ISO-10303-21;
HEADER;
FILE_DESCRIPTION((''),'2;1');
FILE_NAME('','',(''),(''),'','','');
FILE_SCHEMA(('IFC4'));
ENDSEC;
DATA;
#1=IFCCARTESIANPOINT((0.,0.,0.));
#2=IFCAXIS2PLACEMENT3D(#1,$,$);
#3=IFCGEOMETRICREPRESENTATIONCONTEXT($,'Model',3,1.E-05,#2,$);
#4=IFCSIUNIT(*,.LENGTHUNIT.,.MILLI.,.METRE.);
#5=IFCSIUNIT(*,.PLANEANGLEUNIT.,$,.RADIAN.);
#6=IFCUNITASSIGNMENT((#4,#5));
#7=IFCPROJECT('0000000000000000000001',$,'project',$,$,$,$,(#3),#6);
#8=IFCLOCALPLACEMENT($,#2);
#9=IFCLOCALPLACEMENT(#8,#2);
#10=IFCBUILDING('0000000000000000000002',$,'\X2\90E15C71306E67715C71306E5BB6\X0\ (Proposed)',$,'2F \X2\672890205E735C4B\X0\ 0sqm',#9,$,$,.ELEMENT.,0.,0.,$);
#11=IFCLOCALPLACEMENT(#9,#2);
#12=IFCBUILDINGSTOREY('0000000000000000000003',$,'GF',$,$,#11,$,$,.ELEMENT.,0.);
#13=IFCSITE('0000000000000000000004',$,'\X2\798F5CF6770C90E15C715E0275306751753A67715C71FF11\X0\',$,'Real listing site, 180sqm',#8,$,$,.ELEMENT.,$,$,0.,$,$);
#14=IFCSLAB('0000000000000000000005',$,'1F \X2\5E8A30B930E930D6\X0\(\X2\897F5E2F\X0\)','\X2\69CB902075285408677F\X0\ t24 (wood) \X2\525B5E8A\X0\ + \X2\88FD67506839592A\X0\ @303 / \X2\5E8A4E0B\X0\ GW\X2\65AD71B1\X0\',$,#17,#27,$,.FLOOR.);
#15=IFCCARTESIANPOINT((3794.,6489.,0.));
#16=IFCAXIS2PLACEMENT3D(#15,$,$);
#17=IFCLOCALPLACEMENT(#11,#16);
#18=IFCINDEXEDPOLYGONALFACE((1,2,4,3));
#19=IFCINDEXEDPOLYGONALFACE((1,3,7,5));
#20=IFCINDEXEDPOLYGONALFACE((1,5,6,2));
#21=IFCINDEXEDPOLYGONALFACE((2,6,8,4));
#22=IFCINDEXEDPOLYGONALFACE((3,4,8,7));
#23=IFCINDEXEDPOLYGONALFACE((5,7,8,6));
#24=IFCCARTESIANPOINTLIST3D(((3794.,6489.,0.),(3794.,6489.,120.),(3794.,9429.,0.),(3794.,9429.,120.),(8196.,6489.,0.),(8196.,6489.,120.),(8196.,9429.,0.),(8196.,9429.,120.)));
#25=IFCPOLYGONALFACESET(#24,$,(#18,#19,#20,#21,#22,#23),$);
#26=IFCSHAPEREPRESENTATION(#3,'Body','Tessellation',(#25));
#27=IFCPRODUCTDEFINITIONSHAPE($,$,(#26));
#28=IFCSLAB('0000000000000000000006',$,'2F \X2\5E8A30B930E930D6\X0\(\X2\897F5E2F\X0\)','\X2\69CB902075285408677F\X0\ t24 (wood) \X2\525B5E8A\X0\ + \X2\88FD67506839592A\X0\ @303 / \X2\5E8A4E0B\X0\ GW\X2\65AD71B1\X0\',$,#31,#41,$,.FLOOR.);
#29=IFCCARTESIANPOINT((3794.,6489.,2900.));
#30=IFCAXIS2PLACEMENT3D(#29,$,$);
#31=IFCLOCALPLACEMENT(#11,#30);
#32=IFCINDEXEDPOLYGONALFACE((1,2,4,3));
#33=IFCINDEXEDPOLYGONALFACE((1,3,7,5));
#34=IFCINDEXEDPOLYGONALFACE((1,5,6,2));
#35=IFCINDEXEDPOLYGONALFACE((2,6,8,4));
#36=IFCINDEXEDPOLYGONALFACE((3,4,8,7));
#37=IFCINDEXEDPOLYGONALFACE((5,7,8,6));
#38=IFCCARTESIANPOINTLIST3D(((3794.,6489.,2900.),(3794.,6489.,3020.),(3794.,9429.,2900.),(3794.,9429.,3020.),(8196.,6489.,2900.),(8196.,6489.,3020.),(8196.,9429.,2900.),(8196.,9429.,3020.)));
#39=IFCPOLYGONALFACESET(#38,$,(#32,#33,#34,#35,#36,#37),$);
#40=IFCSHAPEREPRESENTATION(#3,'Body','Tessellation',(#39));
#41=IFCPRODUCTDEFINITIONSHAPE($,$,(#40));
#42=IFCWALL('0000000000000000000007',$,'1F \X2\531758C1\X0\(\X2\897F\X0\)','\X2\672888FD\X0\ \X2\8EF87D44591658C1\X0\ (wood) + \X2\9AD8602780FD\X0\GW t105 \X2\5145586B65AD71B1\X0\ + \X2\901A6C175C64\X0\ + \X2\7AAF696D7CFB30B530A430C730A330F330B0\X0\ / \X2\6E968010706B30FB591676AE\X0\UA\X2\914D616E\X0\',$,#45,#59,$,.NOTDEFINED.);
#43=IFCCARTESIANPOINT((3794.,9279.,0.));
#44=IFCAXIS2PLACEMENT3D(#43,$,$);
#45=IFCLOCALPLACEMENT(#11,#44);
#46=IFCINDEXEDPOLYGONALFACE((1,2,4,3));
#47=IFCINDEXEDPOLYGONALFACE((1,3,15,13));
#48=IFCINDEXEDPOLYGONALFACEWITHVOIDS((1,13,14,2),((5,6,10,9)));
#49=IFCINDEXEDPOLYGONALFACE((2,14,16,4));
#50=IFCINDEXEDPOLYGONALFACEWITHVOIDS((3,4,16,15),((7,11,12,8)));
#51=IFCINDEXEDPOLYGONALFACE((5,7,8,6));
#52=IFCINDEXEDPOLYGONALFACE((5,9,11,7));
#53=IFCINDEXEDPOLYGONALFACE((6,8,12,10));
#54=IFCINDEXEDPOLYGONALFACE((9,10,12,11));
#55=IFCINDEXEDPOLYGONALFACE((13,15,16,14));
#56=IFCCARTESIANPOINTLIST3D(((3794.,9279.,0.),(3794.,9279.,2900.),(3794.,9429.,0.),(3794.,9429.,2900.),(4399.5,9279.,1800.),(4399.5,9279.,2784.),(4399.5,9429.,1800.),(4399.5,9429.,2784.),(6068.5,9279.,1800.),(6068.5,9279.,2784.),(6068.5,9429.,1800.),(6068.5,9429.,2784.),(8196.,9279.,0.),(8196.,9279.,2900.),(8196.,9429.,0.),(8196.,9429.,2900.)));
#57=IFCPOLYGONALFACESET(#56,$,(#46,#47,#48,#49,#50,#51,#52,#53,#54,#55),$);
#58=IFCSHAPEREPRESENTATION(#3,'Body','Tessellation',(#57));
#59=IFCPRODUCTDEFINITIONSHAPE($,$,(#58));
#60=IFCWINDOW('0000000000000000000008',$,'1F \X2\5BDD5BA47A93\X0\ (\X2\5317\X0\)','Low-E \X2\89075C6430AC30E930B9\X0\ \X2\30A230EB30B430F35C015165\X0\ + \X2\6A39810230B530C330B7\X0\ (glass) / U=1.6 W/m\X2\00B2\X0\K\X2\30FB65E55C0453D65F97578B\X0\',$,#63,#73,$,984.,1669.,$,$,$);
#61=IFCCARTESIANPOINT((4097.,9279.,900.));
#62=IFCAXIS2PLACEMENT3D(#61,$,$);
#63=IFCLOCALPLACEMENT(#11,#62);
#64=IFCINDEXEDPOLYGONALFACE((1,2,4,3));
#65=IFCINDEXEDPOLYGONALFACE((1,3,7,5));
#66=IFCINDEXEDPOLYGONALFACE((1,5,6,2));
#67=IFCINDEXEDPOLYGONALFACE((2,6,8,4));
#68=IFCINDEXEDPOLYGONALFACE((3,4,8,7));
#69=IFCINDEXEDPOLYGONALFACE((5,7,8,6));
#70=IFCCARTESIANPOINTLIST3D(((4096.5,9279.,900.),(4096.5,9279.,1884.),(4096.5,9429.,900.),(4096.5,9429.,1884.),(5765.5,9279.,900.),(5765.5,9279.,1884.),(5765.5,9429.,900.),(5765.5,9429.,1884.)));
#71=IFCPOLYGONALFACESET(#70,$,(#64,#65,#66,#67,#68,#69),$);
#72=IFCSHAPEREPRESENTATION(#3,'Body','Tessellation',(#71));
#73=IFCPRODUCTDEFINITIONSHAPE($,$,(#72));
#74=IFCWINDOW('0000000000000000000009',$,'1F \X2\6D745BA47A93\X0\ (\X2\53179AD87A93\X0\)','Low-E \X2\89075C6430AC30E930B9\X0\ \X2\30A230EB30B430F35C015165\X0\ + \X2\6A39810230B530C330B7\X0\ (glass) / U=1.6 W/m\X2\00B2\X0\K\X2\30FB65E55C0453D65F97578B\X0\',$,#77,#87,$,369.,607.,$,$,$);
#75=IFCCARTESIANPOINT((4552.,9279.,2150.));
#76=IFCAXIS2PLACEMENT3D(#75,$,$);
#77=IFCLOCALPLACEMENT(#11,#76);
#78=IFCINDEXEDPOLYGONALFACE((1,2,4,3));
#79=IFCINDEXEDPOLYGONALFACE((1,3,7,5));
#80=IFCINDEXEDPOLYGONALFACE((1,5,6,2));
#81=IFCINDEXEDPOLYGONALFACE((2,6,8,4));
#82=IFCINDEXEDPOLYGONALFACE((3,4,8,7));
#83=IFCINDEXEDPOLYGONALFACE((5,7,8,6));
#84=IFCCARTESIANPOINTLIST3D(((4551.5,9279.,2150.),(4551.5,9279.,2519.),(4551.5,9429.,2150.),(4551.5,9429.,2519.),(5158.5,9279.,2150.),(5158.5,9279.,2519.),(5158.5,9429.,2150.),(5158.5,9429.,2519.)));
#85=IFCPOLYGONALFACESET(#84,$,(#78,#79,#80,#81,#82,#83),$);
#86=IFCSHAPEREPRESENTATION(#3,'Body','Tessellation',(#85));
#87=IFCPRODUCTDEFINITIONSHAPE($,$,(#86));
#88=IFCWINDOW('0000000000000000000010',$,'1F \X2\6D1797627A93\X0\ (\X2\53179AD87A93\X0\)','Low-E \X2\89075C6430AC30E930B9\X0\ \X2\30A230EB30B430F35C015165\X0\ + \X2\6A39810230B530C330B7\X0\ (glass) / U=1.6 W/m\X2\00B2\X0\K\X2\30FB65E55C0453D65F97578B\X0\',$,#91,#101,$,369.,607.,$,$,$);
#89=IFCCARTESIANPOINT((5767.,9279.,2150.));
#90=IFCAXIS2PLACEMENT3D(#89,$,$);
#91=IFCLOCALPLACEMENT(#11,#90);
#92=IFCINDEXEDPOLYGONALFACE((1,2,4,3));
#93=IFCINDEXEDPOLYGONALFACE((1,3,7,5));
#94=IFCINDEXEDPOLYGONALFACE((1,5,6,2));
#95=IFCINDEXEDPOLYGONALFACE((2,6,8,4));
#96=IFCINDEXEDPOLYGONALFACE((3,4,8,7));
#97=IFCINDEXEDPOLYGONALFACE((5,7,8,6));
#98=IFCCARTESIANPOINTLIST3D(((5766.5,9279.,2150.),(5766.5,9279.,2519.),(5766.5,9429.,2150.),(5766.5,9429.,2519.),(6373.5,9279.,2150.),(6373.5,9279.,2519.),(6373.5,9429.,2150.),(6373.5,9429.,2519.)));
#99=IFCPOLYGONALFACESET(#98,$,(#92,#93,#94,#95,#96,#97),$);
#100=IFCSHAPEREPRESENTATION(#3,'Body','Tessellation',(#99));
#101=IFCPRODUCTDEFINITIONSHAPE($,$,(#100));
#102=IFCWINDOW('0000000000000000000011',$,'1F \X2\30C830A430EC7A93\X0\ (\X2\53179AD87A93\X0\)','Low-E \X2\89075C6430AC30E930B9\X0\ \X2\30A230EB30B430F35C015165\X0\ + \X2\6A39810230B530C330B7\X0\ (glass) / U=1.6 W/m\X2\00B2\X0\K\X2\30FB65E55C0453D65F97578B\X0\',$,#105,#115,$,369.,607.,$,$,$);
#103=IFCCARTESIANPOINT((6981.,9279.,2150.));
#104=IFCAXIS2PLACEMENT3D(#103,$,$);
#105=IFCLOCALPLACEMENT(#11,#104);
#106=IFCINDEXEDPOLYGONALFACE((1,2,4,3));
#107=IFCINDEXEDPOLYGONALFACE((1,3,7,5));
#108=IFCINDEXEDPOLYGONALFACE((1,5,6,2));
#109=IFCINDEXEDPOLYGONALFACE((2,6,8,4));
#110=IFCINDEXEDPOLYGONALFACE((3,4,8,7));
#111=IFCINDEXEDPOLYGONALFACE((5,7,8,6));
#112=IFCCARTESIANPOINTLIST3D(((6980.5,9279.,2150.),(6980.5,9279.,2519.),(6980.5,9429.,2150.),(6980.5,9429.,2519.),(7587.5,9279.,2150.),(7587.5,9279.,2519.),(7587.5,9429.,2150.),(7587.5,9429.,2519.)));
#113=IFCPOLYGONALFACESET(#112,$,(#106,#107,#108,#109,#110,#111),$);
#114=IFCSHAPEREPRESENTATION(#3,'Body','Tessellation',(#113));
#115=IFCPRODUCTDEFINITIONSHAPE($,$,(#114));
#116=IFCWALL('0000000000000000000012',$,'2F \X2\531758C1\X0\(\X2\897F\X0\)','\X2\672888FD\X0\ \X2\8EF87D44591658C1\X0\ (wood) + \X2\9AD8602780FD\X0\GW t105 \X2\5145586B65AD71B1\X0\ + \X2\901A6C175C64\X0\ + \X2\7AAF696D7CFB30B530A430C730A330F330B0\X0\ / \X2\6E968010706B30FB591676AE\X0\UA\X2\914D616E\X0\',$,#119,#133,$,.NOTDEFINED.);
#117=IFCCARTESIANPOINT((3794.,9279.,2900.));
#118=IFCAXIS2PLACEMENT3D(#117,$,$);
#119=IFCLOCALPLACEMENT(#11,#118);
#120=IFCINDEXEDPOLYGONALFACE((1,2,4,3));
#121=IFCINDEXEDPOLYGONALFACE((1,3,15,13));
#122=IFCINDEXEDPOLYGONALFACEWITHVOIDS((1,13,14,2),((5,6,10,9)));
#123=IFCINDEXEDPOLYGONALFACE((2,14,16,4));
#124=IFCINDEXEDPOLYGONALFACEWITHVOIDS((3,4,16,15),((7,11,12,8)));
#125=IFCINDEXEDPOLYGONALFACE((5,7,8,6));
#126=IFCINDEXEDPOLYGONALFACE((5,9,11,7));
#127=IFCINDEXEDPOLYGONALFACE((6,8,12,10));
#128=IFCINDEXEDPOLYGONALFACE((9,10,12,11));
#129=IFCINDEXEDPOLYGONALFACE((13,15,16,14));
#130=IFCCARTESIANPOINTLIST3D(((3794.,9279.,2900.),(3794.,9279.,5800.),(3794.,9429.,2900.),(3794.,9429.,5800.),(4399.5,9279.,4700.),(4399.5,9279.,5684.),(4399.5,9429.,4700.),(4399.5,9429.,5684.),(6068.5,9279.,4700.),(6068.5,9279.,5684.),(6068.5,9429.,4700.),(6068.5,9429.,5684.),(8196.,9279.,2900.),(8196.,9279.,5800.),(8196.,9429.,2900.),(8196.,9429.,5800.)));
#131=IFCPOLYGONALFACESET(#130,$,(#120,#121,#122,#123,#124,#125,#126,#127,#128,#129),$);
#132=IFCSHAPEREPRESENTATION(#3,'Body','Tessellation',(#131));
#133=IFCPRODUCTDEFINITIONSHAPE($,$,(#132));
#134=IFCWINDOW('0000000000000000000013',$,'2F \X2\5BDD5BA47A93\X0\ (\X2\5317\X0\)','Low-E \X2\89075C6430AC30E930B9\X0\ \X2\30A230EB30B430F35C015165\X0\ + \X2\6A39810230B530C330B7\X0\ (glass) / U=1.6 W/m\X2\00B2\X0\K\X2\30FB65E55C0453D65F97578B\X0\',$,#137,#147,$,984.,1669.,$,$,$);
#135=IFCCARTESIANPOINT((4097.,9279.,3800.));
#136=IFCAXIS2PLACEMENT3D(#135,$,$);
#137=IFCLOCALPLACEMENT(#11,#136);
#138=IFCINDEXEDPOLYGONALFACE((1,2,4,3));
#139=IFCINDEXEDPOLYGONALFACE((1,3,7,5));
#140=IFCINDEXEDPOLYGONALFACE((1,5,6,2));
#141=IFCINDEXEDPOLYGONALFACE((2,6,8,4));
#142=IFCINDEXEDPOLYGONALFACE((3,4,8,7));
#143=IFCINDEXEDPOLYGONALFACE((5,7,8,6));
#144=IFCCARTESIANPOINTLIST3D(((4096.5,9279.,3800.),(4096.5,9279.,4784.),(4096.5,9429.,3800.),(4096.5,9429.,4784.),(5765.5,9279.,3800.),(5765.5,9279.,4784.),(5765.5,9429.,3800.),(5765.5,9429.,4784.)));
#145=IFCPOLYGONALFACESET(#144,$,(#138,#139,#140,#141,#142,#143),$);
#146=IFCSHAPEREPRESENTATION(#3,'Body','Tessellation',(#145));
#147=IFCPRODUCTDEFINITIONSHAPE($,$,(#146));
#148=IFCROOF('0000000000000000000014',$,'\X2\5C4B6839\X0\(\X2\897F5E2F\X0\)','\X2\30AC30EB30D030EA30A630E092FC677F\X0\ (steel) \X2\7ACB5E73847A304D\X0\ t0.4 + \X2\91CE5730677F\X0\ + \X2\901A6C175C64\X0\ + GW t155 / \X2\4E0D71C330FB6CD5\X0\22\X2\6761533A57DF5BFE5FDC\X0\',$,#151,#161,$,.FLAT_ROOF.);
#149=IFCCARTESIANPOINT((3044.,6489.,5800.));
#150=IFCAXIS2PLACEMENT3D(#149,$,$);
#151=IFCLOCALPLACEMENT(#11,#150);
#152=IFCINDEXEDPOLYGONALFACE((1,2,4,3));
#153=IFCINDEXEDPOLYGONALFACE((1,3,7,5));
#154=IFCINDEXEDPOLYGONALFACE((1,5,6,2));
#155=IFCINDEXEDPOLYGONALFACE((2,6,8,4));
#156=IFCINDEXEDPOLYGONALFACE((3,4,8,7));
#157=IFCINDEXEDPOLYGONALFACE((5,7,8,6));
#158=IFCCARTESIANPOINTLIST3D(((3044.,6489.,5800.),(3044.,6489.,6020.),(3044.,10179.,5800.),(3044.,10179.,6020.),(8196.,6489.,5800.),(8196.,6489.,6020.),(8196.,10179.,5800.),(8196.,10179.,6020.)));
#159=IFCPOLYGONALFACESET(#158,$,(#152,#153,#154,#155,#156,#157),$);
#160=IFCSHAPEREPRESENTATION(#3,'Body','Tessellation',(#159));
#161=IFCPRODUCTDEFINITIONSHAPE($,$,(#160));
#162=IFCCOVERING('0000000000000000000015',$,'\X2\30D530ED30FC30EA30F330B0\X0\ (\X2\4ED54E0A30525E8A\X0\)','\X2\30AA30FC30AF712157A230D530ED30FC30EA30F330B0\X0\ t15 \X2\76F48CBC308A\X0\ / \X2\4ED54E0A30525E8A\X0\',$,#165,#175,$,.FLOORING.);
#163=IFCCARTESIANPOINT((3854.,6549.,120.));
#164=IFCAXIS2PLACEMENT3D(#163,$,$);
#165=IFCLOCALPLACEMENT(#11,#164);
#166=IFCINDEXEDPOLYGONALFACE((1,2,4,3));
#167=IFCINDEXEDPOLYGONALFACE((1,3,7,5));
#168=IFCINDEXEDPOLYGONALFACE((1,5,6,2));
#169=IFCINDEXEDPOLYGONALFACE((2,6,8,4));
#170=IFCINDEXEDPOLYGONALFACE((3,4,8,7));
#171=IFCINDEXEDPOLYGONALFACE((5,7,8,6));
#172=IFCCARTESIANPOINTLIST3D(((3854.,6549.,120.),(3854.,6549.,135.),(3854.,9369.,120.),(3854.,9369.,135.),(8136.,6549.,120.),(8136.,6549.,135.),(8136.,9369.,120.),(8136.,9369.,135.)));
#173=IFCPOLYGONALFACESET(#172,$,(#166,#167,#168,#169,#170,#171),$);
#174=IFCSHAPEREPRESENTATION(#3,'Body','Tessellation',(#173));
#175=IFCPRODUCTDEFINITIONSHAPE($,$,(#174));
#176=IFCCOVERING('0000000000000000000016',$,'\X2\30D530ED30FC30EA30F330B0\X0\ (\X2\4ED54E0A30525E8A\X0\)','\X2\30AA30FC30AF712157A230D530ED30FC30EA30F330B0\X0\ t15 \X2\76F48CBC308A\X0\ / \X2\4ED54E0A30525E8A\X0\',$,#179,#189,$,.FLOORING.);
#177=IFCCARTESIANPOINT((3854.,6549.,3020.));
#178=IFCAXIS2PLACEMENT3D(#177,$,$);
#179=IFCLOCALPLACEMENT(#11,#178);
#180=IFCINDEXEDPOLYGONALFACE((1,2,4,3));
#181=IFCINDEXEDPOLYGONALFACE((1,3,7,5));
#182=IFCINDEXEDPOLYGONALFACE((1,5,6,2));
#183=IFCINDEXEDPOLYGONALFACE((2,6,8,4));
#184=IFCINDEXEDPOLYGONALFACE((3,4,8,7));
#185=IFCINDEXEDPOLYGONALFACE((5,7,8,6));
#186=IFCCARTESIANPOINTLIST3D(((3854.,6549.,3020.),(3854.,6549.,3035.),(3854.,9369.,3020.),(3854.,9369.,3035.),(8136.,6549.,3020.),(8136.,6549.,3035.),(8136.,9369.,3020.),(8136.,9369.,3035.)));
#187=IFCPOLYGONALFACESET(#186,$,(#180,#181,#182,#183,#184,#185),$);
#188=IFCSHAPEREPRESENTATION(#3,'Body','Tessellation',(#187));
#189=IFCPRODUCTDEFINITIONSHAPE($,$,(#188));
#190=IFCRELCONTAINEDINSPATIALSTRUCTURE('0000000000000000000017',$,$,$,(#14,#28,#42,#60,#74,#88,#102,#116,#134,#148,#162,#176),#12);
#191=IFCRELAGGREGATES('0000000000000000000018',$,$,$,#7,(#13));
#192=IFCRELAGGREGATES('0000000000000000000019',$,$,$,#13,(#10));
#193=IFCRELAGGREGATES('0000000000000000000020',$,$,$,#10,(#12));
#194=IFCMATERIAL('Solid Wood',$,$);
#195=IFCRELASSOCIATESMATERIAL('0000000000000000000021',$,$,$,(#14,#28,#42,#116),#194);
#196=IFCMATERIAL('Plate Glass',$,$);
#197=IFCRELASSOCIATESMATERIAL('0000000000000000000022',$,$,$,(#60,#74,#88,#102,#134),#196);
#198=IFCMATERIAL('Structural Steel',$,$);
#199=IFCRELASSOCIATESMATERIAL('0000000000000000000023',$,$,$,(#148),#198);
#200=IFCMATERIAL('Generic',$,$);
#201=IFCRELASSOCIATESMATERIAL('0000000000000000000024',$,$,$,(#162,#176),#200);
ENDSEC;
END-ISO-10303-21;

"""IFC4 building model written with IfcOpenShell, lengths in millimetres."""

from ifc_helpers import new_model, si_unit, frame, frame_2d, origin, place, context, project, spatial, rectangle, extrude, material, element, fill, save


model = new_model("IFC4")

# Units and contexts
model_context = context("Model", 3, precision=1e-05, world=origin())
ifc_project = project(units=[si_unit("LENGTHUNIT", "METRE", prefix="MILLI"), si_unit("PLANEANGLEUNIT", "RADIAN")], contexts=[model_context])

# Site, building, storey
site_placement = place(None, origin())
site = spatial("IfcSite", under=ifc_project, at=site_placement, Name="福島県郡山市田村町東山１", ObjectType="Real listing site, 180sqm", CompositionType="ELEMENT", RefElevation=0.0)
building_placement = place(site_placement, origin())
building = spatial("IfcBuilding", under=site, at=building_placement, Name="郡山の東山の家 (Proposed)", ObjectType="2F 木造平屋 0sqm", CompositionType="ELEMENT", ElevationOfRefHeight=0.0, ElevationOfTerrain=0.0)
storey_placement = place(building_placement, origin())
storey = spatial("IfcBuildingStorey", under=building, at=storey_placement, Name="GF", CompositionType="ELEMENT", Elevation=0.0)

# Slabs
ifc_material_1 = material(Name="Solid Wood")
slab_1_placement = place(storey_placement, frame((3794.0, 6489.0, 0.0)))
element("IfcSlab", 1, at=slab_1_placement, inside=storey, material=ifc_material_1, Name="1F 床スラブ(西帯)", Description="構造用合板 t24 (wood) 剛床 + 製材根太 @303 / 床下 GW断熱", PredefinedType="FLOOR", context=model_context, shape_type="SweptSolid", body=[
    extrude(rectangle(XDim=4402.0, YDim=2940.0, at=frame_2d((2201.0, 1470.0))), frame((3794.0, 6489.0, 0.0)), (0.0, 0.0, 1.0), 120.0),
])
slab_2_placement = place(storey_placement, frame((3794.0, 6489.0, 2900.0)))
element("IfcSlab", 2, at=slab_2_placement, inside=storey, material=ifc_material_1, Name="2F 床スラブ(西帯)", Description="構造用合板 t24 (wood) 剛床 + 製材根太 @303 / 床下 GW断熱", PredefinedType="FLOOR", context=model_context, shape_type="SweptSolid", body=[
    extrude(rectangle(XDim=4402.0, YDim=2940.0, at=frame_2d((2201.0, 1470.0))), frame((3794.0, 6489.0, 2900.0)), (0.0, 0.0, 1.0), 120.0),
])

# Wall, openings, windows
wall_1_placement = place(storey_placement, frame((3794.0, 9279.0, 0.0)))
wall_1 = element("IfcWall", 3, at=wall_1_placement, inside=storey, material=ifc_material_1, Name="1F 北壁(西)", Description="木製 軸組外壁 (wood) + 高性能GW t105 充填断熱 + 通気層 + 窯業系サイディング / 準耐火・外皮UA配慮", PredefinedType="NOTDEFINED", context=model_context, shape_type="SweptSolid", body=[
    extrude(rectangle(XDim=4402.0, YDim=150.0, at=frame_2d((2201.0, 75.0))), frame((3794.0, 9279.0, 0.0)), (0.0, 0.0, 1.0), 2900.0),
])
opening_1_placement = place(storey_placement, frame((4097.0, 9279.0, 900.0)))
opening_1 = element("IfcOpeningElement", 4, at=opening_1_placement, cuts=wall_1, PredefinedType="NOTDEFINED", context=model_context, shape_type="SweptSolid", body=[
    extrude(rectangle(XDim=1669.0, YDim=150.0, at=frame_2d((834.0, 75.0))), frame((4097.0, 9279.0, 900.0)), (0.0, 0.0, 1.0), 984.0),
])
opening_2_placement = place(storey_placement, frame((4552.0, 9279.0, 2150.0)))
opening_2 = element("IfcOpeningElement", 5, at=opening_2_placement, cuts=wall_1, PredefinedType="NOTDEFINED", context=model_context, shape_type="SweptSolid", body=[
    extrude(rectangle(XDim=607.0, YDim=150.0, at=frame_2d((303.0, 75.0))), frame((4552.0, 9279.0, 2150.0)), (0.0, 0.0, 1.0), 369.0),
])
opening_3_placement = place(storey_placement, frame((5767.0, 9279.0, 2150.0)))
opening_3 = element("IfcOpeningElement", 6, at=opening_3_placement, cuts=wall_1, PredefinedType="NOTDEFINED", context=model_context, shape_type="SweptSolid", body=[
    extrude(rectangle(XDim=607.0, YDim=150.0, at=frame_2d((303.0, 75.0))), frame((5767.0, 9279.0, 2150.0)), (0.0, 0.0, 1.0), 369.0),
])
opening_4_placement = place(storey_placement, frame((6981.0, 9279.0, 2150.0)))
opening_4 = element("IfcOpeningElement", 7, at=opening_4_placement, cuts=wall_1, PredefinedType="NOTDEFINED", context=model_context, shape_type="SweptSolid", body=[
    extrude(rectangle(XDim=607.0, YDim=150.0, at=frame_2d((303.0, 75.0))), frame((6981.0, 9279.0, 2150.0)), (0.0, 0.0, 1.0), 369.0),
])
ifc_material_2 = material(Name="Plate Glass")
window_1_placement = place(storey_placement, frame((4097.0, 9279.0, 900.0)))
window_1 = element("IfcWindow", 8, at=window_1_placement, inside=storey, material=ifc_material_2, Name="1F 寝室窓 (北)", Description="Low-E 複層ガラス アルゴン封入 + 樹脂サッシ (glass) / U=1.6 W/m²K・日射取得型", OverallHeight=984.0, OverallWidth=1669.0, context=model_context, shape_type="SweptSolid", body=[
    extrude(rectangle(XDim=1669.0, YDim=150.0, at=frame_2d((834.0, 75.0))), frame((4097.0, 9279.0, 900.0)), (0.0, 0.0, 1.0), 984.0),
])
fill(opening_1, window_1)
window_2_placement = place(storey_placement, frame((4552.0, 9279.0, 2150.0)))
window_2 = element("IfcWindow", 9, at=window_2_placement, inside=storey, material=ifc_material_2, Name="1F 浴室窓 (北高窓)", Description="Low-E 複層ガラス アルゴン封入 + 樹脂サッシ (glass) / U=1.6 W/m²K・日射取得型", OverallHeight=369.0, OverallWidth=607.0, context=model_context, shape_type="SweptSolid", body=[
    extrude(rectangle(XDim=607.0, YDim=150.0, at=frame_2d((303.0, 75.0))), frame((4552.0, 9279.0, 2150.0)), (0.0, 0.0, 1.0), 369.0),
])
fill(opening_2, window_2)
window_3_placement = place(storey_placement, frame((5767.0, 9279.0, 2150.0)))
window_3 = element("IfcWindow", 10, at=window_3_placement, inside=storey, material=ifc_material_2, Name="1F 洗面窓 (北高窓)", Description="Low-E 複層ガラス アルゴン封入 + 樹脂サッシ (glass) / U=1.6 W/m²K・日射取得型", OverallHeight=369.0, OverallWidth=607.0, context=model_context, shape_type="SweptSolid", body=[
    extrude(rectangle(XDim=607.0, YDim=150.0, at=frame_2d((303.0, 75.0))), frame((5767.0, 9279.0, 2150.0)), (0.0, 0.0, 1.0), 369.0),
])
fill(opening_3, window_3)
window_4_placement = place(storey_placement, frame((6981.0, 9279.0, 2150.0)))
window_4 = element("IfcWindow", 11, at=window_4_placement, inside=storey, material=ifc_material_2, Name="1F トイレ窓 (北高窓)", Description="Low-E 複層ガラス アルゴン封入 + 樹脂サッシ (glass) / U=1.6 W/m²K・日射取得型", OverallHeight=369.0, OverallWidth=607.0, context=model_context, shape_type="SweptSolid", body=[
    extrude(rectangle(XDim=607.0, YDim=150.0, at=frame_2d((303.0, 75.0))), frame((6981.0, 9279.0, 2150.0)), (0.0, 0.0, 1.0), 369.0),
])
fill(opening_4, window_4)

# Wall, opening, window
wall_2_placement = place(storey_placement, frame((3794.0, 9279.0, 2900.0)))
wall_2 = element("IfcWall", 12, at=wall_2_placement, inside=storey, material=ifc_material_1, Name="2F 北壁(西)", Description="木製 軸組外壁 (wood) + 高性能GW t105 充填断熱 + 通気層 + 窯業系サイディング / 準耐火・外皮UA配慮", PredefinedType="NOTDEFINED", context=model_context, shape_type="SweptSolid", body=[
    extrude(rectangle(XDim=4402.0, YDim=150.0, at=frame_2d((2201.0, 75.0))), frame((3794.0, 9279.0, 2900.0)), (0.0, 0.0, 1.0), 2900.0),
])
opening_5_placement = place(storey_placement, frame((4097.0, 9279.0, 3800.0)))
opening_5 = element("IfcOpeningElement", 13, at=opening_5_placement, cuts=wall_2, PredefinedType="NOTDEFINED", context=model_context, shape_type="SweptSolid", body=[
    extrude(rectangle(XDim=1669.0, YDim=150.0, at=frame_2d((834.0, 75.0))), frame((4097.0, 9279.0, 3800.0)), (0.0, 0.0, 1.0), 984.0),
])
window_5_placement = place(storey_placement, frame((4097.0, 9279.0, 3800.0)))
window_5 = element("IfcWindow", 14, at=window_5_placement, inside=storey, material=ifc_material_2, Name="2F 寝室窓 (北)", Description="Low-E 複層ガラス アルゴン封入 + 樹脂サッシ (glass) / U=1.6 W/m²K・日射取得型", OverallHeight=984.0, OverallWidth=1669.0, context=model_context, shape_type="SweptSolid", body=[
    extrude(rectangle(XDim=1669.0, YDim=150.0, at=frame_2d((834.0, 75.0))), frame((4097.0, 9279.0, 3800.0)), (0.0, 0.0, 1.0), 984.0),
])
fill(opening_5, window_5)

# Roof
ifc_material_3 = material(Name="Structural Steel")
for number, where, name in (
    (15, (3044.0, 6489.0, 5800.0), "屋根(西帯)"),
):
    element("IfcRoof", number, at=place(storey_placement, frame(where)), inside=storey, material=ifc_material_3, Name=name, Description="ガルバリウム鋼板 (steel) 立平葺き t0.4 + 野地板 + 通気層 + GW t155 / 不燃・法22条区域対応", PredefinedType="FLAT_ROOF", context=model_context, shape_type="SweptSolid", body=[
        extrude(rectangle(XDim=5152.0, YDim=3690.0, at=frame_2d((2576.0, 1845.0))), frame((3044.0, 6489.0, 5800.0)), (0.0, 0.0, 1.0), 220.0),
    ])

# Coverings
ifc_material_4 = material(Name="Generic")
covering_1_placement = place(storey_placement, frame((3854.0, 6549.0, 120.0)))
element("IfcCovering", 16, at=covering_1_placement, inside=storey, material=ifc_material_4, Name="フローリング (仕上げ床)", Description="オーク無垢フローリング t15 直貼り / 仕上げ床", PredefinedType="FLOORING", context=model_context, shape_type="SweptSolid", body=[
    extrude(rectangle(XDim=4282.0, YDim=2820.0, at=frame_2d((2141.0, 1410.0))), frame((3854.0, 6549.0, 120.0)), (0.0, 0.0, 1.0), 15.0),
])
covering_2_placement = place(storey_placement, frame((3854.0, 6549.0, 3020.0)))
element("IfcCovering", 17, at=covering_2_placement, inside=storey, material=ifc_material_4, Name="フローリング (仕上げ床)", Description="オーク無垢フローリング t15 直貼り / 仕上げ床", PredefinedType="FLOORING", context=model_context, shape_type="SweptSolid", body=[
    extrude(rectangle(XDim=4282.0, YDim=2820.0, at=frame_2d((2141.0, 1410.0))), frame((3854.0, 6549.0, 3020.0)), (0.0, 0.0, 1.0), 15.0),
])

save(model, "model.ifc")
